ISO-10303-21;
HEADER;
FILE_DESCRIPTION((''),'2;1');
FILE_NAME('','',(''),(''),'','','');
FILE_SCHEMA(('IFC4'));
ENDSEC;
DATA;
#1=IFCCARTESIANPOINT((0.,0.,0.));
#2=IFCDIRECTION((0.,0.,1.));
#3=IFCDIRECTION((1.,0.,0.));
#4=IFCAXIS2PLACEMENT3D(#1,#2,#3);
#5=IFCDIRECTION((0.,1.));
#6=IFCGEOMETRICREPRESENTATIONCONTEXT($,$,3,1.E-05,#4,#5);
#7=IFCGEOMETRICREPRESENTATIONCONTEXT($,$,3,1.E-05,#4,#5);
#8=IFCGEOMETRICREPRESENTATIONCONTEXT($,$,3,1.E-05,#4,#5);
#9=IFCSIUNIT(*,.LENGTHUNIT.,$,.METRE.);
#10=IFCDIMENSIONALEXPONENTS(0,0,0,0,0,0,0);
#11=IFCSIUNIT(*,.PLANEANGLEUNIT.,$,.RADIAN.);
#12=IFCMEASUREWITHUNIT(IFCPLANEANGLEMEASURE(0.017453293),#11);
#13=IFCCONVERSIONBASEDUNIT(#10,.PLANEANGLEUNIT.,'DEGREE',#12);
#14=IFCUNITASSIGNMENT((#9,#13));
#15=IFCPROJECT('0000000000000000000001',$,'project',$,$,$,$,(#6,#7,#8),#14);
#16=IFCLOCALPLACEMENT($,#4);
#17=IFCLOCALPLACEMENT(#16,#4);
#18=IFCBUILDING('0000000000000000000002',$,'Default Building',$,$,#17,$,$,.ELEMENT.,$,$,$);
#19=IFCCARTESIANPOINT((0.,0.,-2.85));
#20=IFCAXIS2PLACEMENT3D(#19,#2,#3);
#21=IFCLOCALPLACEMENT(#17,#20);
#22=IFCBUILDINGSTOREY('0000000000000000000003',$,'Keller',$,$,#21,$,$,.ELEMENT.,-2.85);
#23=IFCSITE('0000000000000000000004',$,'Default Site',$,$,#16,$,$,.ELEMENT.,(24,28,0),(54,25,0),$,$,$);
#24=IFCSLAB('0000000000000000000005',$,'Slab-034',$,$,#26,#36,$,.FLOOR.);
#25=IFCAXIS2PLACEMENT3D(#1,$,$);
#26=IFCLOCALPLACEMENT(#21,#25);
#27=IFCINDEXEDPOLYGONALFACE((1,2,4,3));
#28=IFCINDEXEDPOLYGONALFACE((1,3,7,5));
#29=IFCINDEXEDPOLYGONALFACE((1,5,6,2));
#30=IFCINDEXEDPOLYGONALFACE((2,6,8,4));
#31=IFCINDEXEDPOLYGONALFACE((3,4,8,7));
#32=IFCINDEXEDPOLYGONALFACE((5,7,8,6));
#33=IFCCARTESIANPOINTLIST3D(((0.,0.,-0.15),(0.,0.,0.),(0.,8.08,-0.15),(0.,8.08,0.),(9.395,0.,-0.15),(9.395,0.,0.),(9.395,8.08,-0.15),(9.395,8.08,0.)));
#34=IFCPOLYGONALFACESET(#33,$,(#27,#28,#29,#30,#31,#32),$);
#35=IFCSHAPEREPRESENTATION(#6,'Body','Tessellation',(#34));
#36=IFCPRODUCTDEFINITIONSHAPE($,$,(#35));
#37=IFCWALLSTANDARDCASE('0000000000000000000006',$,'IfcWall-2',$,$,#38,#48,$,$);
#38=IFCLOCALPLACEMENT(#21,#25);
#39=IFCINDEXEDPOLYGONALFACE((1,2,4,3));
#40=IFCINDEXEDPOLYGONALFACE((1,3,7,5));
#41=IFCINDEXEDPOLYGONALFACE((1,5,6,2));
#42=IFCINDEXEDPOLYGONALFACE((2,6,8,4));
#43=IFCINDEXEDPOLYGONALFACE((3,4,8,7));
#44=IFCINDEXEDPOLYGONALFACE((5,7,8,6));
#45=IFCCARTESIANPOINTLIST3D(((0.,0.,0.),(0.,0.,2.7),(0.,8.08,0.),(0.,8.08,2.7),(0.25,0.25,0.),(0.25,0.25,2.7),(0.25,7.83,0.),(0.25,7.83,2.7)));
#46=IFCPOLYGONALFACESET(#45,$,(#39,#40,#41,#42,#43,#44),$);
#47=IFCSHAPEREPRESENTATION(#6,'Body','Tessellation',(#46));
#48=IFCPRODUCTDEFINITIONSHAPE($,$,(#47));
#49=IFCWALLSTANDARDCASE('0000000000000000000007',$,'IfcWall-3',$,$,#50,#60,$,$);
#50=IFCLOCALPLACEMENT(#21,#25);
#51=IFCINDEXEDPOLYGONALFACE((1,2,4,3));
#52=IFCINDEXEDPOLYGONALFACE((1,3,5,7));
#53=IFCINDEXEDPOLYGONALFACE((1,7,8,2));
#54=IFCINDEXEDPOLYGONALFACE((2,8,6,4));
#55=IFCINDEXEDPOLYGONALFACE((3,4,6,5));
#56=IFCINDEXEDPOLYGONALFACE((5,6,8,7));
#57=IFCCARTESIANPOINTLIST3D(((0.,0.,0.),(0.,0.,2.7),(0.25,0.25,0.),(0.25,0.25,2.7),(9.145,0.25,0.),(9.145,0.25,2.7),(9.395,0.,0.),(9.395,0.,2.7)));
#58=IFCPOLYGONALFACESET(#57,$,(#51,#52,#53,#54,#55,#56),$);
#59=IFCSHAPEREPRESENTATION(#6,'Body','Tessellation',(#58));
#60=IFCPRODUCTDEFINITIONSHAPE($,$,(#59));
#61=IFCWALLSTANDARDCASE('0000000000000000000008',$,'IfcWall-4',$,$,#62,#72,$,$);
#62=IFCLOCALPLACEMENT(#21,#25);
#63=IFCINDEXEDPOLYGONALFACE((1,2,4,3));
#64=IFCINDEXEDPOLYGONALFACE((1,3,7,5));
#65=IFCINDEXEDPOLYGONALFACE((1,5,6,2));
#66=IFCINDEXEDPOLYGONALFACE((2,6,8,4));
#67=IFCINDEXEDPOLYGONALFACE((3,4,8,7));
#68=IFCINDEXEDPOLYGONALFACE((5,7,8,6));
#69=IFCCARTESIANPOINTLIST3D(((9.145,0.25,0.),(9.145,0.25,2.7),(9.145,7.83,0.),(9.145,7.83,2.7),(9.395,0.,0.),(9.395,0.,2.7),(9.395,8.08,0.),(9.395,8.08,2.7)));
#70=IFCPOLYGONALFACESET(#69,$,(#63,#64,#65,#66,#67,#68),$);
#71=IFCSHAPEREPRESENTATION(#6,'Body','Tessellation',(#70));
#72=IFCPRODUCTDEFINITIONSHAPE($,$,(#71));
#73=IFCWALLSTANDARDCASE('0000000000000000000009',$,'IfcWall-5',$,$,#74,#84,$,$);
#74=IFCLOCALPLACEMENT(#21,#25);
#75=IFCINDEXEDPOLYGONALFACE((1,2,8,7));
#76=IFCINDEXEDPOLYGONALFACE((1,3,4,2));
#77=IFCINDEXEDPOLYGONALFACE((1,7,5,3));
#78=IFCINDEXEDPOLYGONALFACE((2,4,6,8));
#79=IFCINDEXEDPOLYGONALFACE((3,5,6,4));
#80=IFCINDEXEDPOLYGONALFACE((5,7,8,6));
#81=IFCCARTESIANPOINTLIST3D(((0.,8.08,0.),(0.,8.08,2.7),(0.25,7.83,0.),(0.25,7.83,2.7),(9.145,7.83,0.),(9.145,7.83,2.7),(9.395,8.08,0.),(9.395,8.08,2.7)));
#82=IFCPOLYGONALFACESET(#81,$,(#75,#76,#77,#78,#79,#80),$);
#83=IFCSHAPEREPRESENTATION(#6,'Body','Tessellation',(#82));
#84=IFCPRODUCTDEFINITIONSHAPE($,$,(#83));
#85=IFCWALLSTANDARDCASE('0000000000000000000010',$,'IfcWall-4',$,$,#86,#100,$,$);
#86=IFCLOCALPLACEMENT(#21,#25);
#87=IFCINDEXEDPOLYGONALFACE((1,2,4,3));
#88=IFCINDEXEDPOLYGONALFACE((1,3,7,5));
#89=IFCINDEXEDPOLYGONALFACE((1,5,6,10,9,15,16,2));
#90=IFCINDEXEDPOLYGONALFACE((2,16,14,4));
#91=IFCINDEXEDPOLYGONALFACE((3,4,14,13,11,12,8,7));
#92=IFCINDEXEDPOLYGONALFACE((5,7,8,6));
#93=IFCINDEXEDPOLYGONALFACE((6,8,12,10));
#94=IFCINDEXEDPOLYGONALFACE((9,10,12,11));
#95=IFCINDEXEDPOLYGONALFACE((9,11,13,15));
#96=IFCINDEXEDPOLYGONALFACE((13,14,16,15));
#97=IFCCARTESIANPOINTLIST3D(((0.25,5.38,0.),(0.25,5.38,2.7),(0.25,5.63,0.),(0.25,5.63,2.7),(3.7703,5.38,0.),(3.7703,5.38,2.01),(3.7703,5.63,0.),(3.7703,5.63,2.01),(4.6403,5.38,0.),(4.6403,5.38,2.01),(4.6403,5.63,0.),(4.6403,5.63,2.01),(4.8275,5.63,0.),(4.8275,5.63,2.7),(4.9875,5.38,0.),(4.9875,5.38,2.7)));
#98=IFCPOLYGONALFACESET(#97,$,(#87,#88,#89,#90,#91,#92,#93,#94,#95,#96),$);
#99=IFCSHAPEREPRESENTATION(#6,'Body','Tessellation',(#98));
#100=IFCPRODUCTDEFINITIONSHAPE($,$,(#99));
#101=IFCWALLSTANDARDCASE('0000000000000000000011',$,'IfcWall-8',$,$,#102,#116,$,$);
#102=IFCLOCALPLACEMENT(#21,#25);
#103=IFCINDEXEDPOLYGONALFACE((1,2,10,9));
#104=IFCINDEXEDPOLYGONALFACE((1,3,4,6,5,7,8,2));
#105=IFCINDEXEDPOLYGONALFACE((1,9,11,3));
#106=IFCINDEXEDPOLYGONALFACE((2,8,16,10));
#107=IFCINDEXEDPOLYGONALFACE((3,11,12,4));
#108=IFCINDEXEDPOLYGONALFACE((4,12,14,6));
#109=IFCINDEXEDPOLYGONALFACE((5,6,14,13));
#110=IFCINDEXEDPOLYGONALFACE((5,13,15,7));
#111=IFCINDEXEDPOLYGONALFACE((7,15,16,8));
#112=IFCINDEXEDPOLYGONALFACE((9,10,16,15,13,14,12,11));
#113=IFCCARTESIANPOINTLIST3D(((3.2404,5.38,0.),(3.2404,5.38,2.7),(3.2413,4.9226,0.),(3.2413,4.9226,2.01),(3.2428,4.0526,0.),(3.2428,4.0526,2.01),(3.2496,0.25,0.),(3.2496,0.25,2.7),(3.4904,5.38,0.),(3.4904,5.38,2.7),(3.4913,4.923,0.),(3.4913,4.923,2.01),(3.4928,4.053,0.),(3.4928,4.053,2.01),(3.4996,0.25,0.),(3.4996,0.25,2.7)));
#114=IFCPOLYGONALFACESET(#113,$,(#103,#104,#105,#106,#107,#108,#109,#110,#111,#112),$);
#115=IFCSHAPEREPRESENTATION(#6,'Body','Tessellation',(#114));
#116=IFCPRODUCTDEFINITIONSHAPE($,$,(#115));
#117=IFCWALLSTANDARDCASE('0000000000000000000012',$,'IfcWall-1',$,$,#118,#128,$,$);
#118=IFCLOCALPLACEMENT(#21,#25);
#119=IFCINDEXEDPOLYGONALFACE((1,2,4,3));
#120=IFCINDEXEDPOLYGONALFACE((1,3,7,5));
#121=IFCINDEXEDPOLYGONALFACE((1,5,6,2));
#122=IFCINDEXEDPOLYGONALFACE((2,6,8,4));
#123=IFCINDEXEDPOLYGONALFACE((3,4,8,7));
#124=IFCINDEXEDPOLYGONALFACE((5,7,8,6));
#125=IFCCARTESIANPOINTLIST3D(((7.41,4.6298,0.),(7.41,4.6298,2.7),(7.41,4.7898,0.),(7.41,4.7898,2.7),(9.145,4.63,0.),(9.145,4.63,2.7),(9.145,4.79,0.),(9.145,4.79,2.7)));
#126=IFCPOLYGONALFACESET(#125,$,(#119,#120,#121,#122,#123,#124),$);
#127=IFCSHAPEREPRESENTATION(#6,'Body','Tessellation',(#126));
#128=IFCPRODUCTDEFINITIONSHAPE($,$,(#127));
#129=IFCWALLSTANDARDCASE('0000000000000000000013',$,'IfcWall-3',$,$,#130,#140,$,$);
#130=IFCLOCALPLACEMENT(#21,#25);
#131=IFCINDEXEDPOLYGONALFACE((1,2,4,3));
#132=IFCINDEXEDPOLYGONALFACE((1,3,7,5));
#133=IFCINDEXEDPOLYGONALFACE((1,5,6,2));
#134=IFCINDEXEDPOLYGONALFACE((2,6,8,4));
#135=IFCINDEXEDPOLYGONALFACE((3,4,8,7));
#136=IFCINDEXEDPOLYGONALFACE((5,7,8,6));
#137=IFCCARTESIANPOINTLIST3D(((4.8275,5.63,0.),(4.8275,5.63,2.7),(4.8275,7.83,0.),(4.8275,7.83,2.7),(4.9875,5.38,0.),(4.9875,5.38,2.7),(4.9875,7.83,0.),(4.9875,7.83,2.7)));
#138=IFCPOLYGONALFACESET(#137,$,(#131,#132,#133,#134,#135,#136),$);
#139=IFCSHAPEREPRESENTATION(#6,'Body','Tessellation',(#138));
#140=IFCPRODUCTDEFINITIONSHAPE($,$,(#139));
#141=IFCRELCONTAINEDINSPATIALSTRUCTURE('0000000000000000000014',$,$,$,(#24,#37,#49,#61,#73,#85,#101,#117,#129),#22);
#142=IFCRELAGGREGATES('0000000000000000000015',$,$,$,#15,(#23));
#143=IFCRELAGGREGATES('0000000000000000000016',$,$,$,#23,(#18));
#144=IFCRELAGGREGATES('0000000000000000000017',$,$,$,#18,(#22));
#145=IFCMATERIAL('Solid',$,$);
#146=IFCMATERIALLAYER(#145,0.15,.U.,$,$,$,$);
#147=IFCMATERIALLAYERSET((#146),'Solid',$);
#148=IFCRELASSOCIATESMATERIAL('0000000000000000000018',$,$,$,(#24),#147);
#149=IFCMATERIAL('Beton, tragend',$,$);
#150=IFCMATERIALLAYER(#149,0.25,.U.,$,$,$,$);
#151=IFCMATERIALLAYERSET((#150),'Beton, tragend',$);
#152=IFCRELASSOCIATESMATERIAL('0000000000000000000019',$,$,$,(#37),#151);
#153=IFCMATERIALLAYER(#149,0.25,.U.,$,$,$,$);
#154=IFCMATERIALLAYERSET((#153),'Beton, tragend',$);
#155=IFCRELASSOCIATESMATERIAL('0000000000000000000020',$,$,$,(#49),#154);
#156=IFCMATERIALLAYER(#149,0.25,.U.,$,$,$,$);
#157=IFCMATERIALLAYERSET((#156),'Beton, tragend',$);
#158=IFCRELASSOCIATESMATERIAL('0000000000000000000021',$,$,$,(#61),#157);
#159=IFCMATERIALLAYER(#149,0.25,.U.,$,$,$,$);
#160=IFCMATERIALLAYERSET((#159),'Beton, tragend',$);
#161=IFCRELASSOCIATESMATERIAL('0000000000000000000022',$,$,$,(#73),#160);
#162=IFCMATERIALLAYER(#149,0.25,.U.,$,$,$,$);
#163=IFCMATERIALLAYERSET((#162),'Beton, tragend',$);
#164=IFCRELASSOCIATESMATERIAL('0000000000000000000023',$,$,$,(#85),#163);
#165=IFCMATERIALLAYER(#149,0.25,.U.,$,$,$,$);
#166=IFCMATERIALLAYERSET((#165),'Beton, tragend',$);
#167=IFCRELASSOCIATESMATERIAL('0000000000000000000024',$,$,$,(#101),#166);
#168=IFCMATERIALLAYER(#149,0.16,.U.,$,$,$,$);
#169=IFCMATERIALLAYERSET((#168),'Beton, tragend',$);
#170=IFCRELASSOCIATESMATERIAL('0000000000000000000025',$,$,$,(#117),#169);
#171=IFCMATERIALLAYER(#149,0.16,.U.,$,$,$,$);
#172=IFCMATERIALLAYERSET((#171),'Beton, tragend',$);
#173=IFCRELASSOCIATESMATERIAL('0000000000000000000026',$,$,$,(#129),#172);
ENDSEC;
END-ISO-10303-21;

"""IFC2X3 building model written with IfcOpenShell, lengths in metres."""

from ifc_helpers import new_model, entity, si_unit, converted_unit, direction, frame, frame_2d, origin_with_axes, place, context, project, spatial, polyline, rectangle, outline, extrude, material, layer, layer_set, layer_usage, element, save


model = new_model("IFC2X3")

# Units and contexts
context_of_model_1 = context(None, 3, precision=1e-05, world=origin_with_axes(), true_north=direction((0.0, 1.0)))
context_of_model_2 = context(None, 3, precision=1e-05, world=origin_with_axes(), true_north=direction((0.0, 1.0)))
context_of_model_3 = context(None, 3, precision=1e-05, world=origin_with_axes(), true_north=direction((0.0, 1.0)))
ifc_project = project(units=[si_unit("LENGTHUNIT", "METRE"), converted_unit("PLANEANGLEUNIT", "DEGREE", entity("IfcPlaneAngleMeasure", 0.017453293), si_unit("PLANEANGLEUNIT", "RADIAN"), dimensions=[0, 0, 0, 0, 0, 0, 0])], contexts=[context_of_model_1, context_of_model_2, context_of_model_3])

# Site, building, storey
site_placement = place(None, origin_with_axes())
site = spatial("IfcSite", under=ifc_project, at=site_placement, Name="Default Site", CompositionType="ELEMENT", RefLatitude=(24, 28, 0), RefLongitude=(54, 25, 0))
building_placement = place(site_placement, origin_with_axes())
building = spatial("IfcBuilding", under=site, at=building_placement, Name="Default Building", CompositionType="ELEMENT")
storey_placement = place(building_placement, frame((0.0, 0.0, -2.85), z_axis=(0.0, 0.0, 1.0), x_axis=(1.0, 0.0, 0.0)))
storey = spatial("IfcBuildingStorey", under=building, at=storey_placement, Name="Keller", CompositionType="ELEMENT", Elevation=-2.85)

# Slab
ifc_material_1 = material(Name="Solid")
ifc_layer_1 = layer(ifc_material_1, 0.15, ventilated="UNKNOWN")
ifc_layer_set_1 = layer_set([ifc_layer_1], Name="Solid")
ifc_layer_usage_1 = layer_usage(ifc_layer_set_1, "AXIS3", "NEGATIVE", 0.15)
slab_placement = place(storey_placement, frame((0.0, 8.08, -0.15), z_axis=(0.0, 0.0, 1.0), x_axis=(1.0, 0.0, 0.0)))
element("IfcSlab", 1, at=slab_placement, inside=storey, material=ifc_layer_usage_1, Name="Slab-034", PredefinedType="FLOOR", context=context_of_model_1, shape_type="SweptSolid", body=[
    extrude(outline(polyline([(0.0, 0.0), (9.395, 0.0), (9.395, -8.08), (0.0, -8.08), (0.0, 0.0)])), origin_with_axes(), (0.0, 0.0, 1.0), 0.15),
])

# Walls
ifc_material_2 = material(Name="Beton, tragend")
ifc_layer_2 = layer(ifc_material_2, 0.25, ventilated="UNKNOWN")
ifc_layer_set_2 = layer_set([ifc_layer_2], Name="Beton, tragend")
ifc_layer_usage_2 = layer_usage(ifc_layer_set_2, "AXIS2", "POSITIVE", 0.0)
wall_1_placement = place(storey_placement, frame((0.0, 8.08, 0.0), z_axis=(0.0, 0.0, 1.0), x_axis=(0.0, -1.0, 0.0)))
element("IfcWallStandardCase", 2, at=wall_1_placement, inside=storey, material=ifc_layer_usage_2, Name="IfcWall-2", context=context_of_model_1, shape_type="SweptSolid", body=[
    extrude(outline(polyline([(0.0, 0.0), (8.08, 0.0), (7.83, 0.25), (0.25, 0.25), (0.0, 0.0)])), origin_with_axes(), (0.0, 0.0, 1.0), 2.7),
])
ifc_layer_3 = layer(ifc_material_2, 0.25, ventilated="UNKNOWN")
ifc_layer_set_3 = layer_set([ifc_layer_3], Name="Beton, tragend")
ifc_layer_usage_3 = layer_usage(ifc_layer_set_3, "AXIS2", "POSITIVE", 0.0)
wall_2_placement = place(storey_placement, origin_with_axes())
element("IfcWallStandardCase", 3, at=wall_2_placement, inside=storey, material=ifc_layer_usage_3, Name="IfcWall-3", context=context_of_model_1, shape_type="SweptSolid", body=[
    extrude(outline(polyline([(0.0, 0.0), (9.395, 0.0), (9.145, 0.25), (0.25, 0.25), (0.0, 0.0)])), origin_with_axes(), (0.0, 0.0, 1.0), 2.7),
])
ifc_layer_4 = layer(ifc_material_2, 0.25, ventilated="UNKNOWN")
ifc_layer_set_4 = layer_set([ifc_layer_4], Name="Beton, tragend")
ifc_layer_usage_4 = layer_usage(ifc_layer_set_4, "AXIS2", "POSITIVE", 0.0)
wall_3_placement = place(storey_placement, frame((9.395, 0.0, 0.0), z_axis=(0.0, 0.0, 1.0), x_axis=(0.0, 1.0, 0.0)))
element("IfcWallStandardCase", 4, at=wall_3_placement, inside=storey, material=ifc_layer_usage_4, Name="IfcWall-4", context=context_of_model_1, shape_type="SweptSolid", body=[
    extrude(outline(polyline([(0.0, 0.0), (8.08, 0.0), (7.83, 0.25), (0.25, 0.25), (0.0, 0.0)])), origin_with_axes(), (0.0, 0.0, 1.0), 2.7),
])
ifc_layer_5 = layer(ifc_material_2, 0.25, ventilated="UNKNOWN")
ifc_layer_set_5 = layer_set([ifc_layer_5], Name="Beton, tragend")
ifc_layer_usage_5 = layer_usage(ifc_layer_set_5, "AXIS2", "POSITIVE", 0.0)
wall_4_placement = place(storey_placement, frame((9.395, 8.08, 0.0), z_axis=(0.0, 0.0, 1.0), x_axis=(-1.0, 0.0, 0.0)))
element("IfcWallStandardCase", 5, at=wall_4_placement, inside=storey, material=ifc_layer_usage_5, Name="IfcWall-5", context=context_of_model_1, shape_type="SweptSolid", body=[
    extrude(outline(polyline([(0.0, 0.0), (9.395, 0.0), (9.145, 0.25), (0.25, 0.25), (0.0, 0.0)])), origin_with_axes(), (0.0, 0.0, 1.0), 2.7),
])

# Walls, openings
ifc_layer_6 = layer(ifc_material_2, 0.25, ventilated="UNKNOWN")
ifc_layer_set_6 = layer_set([ifc_layer_6], Name="Beton, tragend")
ifc_layer_usage_6 = layer_usage(ifc_layer_set_6, "AXIS2", "POSITIVE", 0.0)
wall_5_placement = place(storey_placement, frame((4.8275, 5.63, 0.0), z_axis=(0.0, 0.0, 1.0), x_axis=(-1.0, 0.0, 0.0)))
wall_5 = element("IfcWallStandardCase", 6, at=wall_5_placement, inside=storey, material=ifc_layer_usage_6, Name="IfcWall-4", context=context_of_model_1, shape_type="SweptSolid", body=[
    extrude(outline(polyline([(0.0, 0.0), (4.5775, 0.0), (4.5775, 0.25), (-0.16, 0.25), (0.0, 0.0)])), origin_with_axes(), (0.0, 0.0, 1.0), 2.7),
])
opening_1_placement = place(wall_5_placement, frame((0.6222, 0.0, 0.0), z_axis=(0.0, 0.0, 1.0), x_axis=(1.0, 0.0, 0.0)))
element("IfcOpeningElement", 7, at=opening_1_placement, cuts=wall_5, context=context_of_model_1, shape_type="SweptSolid", body=[
    extrude(rectangle(XDim=2.01, YDim=0.87, at=frame_2d((0.0, 1.005), x_axis=(0.0, -1.0))), frame((0.0, 0.0, 0.0), z_axis=(0.0, 1.0, 0.0), x_axis=(-1.0, 0.0, 0.0)), (0.0, 0.0, 1.0), 0.25),
])
ifc_layer_7 = layer(ifc_material_2, 0.25, ventilated="UNKNOWN")
ifc_layer_set_7 = layer_set([ifc_layer_7], Name="Beton, tragend")
ifc_layer_usage_7 = layer_usage(ifc_layer_set_7, "AXIS2", "POSITIVE", 0.0)
wall_6_placement = place(storey_placement, frame((3.5, 0.0, 0.0), z_axis=(0.0, 0.0, 1.0), x_axis=(-0.001776, 0.999998, 0.0)))
wall_6 = element("IfcWallStandardCase", 8, at=wall_6_placement, inside=storey, material=ifc_layer_usage_7, Name="IfcWall-8", context=context_of_model_1, shape_type="SweptSolid", body=[
    extrude(outline(polyline([(0.25, 0.0), (5.38, 0.0), (5.3805, 0.25), (0.2504, 0.25), (0.25, 0.0)])), origin_with_axes(), (0.0, 0.0, 1.0), 2.7),
])
opening_2_placement = place(wall_6_placement, frame((4.488, 0.0, 0.0), z_axis=(0.0, 0.0, 1.0), x_axis=(1.0, 0.0, 0.0)))
element("IfcOpeningElement", 9, at=opening_2_placement, cuts=wall_6, context=context_of_model_1, shape_type="SweptSolid", body=[
    extrude(rectangle(XDim=2.01, YDim=0.87, at=frame_2d((0.0, 1.005), x_axis=(0.0, -1.0))), frame((0.0, 0.0, 0.0), z_axis=(0.0, 1.0, 0.0), x_axis=(-1.0, 0.0, 0.0)), (0.0, 0.0, 1.0), 0.25),
])

# Wall
ifc_layer_8 = layer(ifc_material_2, 0.16, ventilated="UNKNOWN")
ifc_layer_set_8 = layer_set([ifc_layer_8], Name="Beton, tragend")
ifc_layer_usage_8 = layer_usage(ifc_layer_set_8, "AXIS2", "NEGATIVE", 0.0)
wall_7_placement = place(storey_placement, frame((7.41, 4.7898, 0.0), z_axis=(0.0, 0.0, 1.0), x_axis=(1.0, 0.000122, 0.0)))
element("IfcWallStandardCase", 10, at=wall_7_placement, inside=storey, material=ifc_layer_usage_8, Name="IfcWall-1", context=context_of_model_1, shape_type="SweptSolid", body=[
    extrude(outline(polyline([(0.0, -0.16), (1.735, -0.16), (1.735, 0.0), (0.0, 0.0), (0.0, -0.16)])), origin_with_axes(), (0.0, 0.0, 1.0), 2.7),
])

# Wall
ifc_layer_9 = layer(ifc_material_2, 0.16, ventilated="UNKNOWN")
ifc_layer_set_9 = layer_set([ifc_layer_9], Name="Beton, tragend")
ifc_layer_usage_9 = layer_usage(ifc_layer_set_9, "AXIS2", "NEGATIVE", 0.0)
wall_8_placement = place(storey_placement, frame((4.8275, 5.63, 0.0), z_axis=(0.0, 0.0, 1.0), x_axis=(0.0, 1.0, 0.0)))
element("IfcWallStandardCase", 11, at=wall_8_placement, inside=storey, material=ifc_layer_usage_9, Name="IfcWall-3", context=context_of_model_1, shape_type="SweptSolid", body=[
    extrude(outline(polyline([(-0.25, -0.16), (2.2, -0.16), (2.2, 0.0), (0.0, 0.0), (-0.25, -0.16)])), origin_with_axes(), (0.0, 0.0, 1.0), 2.7),
])

save(model, "model.ifc")
